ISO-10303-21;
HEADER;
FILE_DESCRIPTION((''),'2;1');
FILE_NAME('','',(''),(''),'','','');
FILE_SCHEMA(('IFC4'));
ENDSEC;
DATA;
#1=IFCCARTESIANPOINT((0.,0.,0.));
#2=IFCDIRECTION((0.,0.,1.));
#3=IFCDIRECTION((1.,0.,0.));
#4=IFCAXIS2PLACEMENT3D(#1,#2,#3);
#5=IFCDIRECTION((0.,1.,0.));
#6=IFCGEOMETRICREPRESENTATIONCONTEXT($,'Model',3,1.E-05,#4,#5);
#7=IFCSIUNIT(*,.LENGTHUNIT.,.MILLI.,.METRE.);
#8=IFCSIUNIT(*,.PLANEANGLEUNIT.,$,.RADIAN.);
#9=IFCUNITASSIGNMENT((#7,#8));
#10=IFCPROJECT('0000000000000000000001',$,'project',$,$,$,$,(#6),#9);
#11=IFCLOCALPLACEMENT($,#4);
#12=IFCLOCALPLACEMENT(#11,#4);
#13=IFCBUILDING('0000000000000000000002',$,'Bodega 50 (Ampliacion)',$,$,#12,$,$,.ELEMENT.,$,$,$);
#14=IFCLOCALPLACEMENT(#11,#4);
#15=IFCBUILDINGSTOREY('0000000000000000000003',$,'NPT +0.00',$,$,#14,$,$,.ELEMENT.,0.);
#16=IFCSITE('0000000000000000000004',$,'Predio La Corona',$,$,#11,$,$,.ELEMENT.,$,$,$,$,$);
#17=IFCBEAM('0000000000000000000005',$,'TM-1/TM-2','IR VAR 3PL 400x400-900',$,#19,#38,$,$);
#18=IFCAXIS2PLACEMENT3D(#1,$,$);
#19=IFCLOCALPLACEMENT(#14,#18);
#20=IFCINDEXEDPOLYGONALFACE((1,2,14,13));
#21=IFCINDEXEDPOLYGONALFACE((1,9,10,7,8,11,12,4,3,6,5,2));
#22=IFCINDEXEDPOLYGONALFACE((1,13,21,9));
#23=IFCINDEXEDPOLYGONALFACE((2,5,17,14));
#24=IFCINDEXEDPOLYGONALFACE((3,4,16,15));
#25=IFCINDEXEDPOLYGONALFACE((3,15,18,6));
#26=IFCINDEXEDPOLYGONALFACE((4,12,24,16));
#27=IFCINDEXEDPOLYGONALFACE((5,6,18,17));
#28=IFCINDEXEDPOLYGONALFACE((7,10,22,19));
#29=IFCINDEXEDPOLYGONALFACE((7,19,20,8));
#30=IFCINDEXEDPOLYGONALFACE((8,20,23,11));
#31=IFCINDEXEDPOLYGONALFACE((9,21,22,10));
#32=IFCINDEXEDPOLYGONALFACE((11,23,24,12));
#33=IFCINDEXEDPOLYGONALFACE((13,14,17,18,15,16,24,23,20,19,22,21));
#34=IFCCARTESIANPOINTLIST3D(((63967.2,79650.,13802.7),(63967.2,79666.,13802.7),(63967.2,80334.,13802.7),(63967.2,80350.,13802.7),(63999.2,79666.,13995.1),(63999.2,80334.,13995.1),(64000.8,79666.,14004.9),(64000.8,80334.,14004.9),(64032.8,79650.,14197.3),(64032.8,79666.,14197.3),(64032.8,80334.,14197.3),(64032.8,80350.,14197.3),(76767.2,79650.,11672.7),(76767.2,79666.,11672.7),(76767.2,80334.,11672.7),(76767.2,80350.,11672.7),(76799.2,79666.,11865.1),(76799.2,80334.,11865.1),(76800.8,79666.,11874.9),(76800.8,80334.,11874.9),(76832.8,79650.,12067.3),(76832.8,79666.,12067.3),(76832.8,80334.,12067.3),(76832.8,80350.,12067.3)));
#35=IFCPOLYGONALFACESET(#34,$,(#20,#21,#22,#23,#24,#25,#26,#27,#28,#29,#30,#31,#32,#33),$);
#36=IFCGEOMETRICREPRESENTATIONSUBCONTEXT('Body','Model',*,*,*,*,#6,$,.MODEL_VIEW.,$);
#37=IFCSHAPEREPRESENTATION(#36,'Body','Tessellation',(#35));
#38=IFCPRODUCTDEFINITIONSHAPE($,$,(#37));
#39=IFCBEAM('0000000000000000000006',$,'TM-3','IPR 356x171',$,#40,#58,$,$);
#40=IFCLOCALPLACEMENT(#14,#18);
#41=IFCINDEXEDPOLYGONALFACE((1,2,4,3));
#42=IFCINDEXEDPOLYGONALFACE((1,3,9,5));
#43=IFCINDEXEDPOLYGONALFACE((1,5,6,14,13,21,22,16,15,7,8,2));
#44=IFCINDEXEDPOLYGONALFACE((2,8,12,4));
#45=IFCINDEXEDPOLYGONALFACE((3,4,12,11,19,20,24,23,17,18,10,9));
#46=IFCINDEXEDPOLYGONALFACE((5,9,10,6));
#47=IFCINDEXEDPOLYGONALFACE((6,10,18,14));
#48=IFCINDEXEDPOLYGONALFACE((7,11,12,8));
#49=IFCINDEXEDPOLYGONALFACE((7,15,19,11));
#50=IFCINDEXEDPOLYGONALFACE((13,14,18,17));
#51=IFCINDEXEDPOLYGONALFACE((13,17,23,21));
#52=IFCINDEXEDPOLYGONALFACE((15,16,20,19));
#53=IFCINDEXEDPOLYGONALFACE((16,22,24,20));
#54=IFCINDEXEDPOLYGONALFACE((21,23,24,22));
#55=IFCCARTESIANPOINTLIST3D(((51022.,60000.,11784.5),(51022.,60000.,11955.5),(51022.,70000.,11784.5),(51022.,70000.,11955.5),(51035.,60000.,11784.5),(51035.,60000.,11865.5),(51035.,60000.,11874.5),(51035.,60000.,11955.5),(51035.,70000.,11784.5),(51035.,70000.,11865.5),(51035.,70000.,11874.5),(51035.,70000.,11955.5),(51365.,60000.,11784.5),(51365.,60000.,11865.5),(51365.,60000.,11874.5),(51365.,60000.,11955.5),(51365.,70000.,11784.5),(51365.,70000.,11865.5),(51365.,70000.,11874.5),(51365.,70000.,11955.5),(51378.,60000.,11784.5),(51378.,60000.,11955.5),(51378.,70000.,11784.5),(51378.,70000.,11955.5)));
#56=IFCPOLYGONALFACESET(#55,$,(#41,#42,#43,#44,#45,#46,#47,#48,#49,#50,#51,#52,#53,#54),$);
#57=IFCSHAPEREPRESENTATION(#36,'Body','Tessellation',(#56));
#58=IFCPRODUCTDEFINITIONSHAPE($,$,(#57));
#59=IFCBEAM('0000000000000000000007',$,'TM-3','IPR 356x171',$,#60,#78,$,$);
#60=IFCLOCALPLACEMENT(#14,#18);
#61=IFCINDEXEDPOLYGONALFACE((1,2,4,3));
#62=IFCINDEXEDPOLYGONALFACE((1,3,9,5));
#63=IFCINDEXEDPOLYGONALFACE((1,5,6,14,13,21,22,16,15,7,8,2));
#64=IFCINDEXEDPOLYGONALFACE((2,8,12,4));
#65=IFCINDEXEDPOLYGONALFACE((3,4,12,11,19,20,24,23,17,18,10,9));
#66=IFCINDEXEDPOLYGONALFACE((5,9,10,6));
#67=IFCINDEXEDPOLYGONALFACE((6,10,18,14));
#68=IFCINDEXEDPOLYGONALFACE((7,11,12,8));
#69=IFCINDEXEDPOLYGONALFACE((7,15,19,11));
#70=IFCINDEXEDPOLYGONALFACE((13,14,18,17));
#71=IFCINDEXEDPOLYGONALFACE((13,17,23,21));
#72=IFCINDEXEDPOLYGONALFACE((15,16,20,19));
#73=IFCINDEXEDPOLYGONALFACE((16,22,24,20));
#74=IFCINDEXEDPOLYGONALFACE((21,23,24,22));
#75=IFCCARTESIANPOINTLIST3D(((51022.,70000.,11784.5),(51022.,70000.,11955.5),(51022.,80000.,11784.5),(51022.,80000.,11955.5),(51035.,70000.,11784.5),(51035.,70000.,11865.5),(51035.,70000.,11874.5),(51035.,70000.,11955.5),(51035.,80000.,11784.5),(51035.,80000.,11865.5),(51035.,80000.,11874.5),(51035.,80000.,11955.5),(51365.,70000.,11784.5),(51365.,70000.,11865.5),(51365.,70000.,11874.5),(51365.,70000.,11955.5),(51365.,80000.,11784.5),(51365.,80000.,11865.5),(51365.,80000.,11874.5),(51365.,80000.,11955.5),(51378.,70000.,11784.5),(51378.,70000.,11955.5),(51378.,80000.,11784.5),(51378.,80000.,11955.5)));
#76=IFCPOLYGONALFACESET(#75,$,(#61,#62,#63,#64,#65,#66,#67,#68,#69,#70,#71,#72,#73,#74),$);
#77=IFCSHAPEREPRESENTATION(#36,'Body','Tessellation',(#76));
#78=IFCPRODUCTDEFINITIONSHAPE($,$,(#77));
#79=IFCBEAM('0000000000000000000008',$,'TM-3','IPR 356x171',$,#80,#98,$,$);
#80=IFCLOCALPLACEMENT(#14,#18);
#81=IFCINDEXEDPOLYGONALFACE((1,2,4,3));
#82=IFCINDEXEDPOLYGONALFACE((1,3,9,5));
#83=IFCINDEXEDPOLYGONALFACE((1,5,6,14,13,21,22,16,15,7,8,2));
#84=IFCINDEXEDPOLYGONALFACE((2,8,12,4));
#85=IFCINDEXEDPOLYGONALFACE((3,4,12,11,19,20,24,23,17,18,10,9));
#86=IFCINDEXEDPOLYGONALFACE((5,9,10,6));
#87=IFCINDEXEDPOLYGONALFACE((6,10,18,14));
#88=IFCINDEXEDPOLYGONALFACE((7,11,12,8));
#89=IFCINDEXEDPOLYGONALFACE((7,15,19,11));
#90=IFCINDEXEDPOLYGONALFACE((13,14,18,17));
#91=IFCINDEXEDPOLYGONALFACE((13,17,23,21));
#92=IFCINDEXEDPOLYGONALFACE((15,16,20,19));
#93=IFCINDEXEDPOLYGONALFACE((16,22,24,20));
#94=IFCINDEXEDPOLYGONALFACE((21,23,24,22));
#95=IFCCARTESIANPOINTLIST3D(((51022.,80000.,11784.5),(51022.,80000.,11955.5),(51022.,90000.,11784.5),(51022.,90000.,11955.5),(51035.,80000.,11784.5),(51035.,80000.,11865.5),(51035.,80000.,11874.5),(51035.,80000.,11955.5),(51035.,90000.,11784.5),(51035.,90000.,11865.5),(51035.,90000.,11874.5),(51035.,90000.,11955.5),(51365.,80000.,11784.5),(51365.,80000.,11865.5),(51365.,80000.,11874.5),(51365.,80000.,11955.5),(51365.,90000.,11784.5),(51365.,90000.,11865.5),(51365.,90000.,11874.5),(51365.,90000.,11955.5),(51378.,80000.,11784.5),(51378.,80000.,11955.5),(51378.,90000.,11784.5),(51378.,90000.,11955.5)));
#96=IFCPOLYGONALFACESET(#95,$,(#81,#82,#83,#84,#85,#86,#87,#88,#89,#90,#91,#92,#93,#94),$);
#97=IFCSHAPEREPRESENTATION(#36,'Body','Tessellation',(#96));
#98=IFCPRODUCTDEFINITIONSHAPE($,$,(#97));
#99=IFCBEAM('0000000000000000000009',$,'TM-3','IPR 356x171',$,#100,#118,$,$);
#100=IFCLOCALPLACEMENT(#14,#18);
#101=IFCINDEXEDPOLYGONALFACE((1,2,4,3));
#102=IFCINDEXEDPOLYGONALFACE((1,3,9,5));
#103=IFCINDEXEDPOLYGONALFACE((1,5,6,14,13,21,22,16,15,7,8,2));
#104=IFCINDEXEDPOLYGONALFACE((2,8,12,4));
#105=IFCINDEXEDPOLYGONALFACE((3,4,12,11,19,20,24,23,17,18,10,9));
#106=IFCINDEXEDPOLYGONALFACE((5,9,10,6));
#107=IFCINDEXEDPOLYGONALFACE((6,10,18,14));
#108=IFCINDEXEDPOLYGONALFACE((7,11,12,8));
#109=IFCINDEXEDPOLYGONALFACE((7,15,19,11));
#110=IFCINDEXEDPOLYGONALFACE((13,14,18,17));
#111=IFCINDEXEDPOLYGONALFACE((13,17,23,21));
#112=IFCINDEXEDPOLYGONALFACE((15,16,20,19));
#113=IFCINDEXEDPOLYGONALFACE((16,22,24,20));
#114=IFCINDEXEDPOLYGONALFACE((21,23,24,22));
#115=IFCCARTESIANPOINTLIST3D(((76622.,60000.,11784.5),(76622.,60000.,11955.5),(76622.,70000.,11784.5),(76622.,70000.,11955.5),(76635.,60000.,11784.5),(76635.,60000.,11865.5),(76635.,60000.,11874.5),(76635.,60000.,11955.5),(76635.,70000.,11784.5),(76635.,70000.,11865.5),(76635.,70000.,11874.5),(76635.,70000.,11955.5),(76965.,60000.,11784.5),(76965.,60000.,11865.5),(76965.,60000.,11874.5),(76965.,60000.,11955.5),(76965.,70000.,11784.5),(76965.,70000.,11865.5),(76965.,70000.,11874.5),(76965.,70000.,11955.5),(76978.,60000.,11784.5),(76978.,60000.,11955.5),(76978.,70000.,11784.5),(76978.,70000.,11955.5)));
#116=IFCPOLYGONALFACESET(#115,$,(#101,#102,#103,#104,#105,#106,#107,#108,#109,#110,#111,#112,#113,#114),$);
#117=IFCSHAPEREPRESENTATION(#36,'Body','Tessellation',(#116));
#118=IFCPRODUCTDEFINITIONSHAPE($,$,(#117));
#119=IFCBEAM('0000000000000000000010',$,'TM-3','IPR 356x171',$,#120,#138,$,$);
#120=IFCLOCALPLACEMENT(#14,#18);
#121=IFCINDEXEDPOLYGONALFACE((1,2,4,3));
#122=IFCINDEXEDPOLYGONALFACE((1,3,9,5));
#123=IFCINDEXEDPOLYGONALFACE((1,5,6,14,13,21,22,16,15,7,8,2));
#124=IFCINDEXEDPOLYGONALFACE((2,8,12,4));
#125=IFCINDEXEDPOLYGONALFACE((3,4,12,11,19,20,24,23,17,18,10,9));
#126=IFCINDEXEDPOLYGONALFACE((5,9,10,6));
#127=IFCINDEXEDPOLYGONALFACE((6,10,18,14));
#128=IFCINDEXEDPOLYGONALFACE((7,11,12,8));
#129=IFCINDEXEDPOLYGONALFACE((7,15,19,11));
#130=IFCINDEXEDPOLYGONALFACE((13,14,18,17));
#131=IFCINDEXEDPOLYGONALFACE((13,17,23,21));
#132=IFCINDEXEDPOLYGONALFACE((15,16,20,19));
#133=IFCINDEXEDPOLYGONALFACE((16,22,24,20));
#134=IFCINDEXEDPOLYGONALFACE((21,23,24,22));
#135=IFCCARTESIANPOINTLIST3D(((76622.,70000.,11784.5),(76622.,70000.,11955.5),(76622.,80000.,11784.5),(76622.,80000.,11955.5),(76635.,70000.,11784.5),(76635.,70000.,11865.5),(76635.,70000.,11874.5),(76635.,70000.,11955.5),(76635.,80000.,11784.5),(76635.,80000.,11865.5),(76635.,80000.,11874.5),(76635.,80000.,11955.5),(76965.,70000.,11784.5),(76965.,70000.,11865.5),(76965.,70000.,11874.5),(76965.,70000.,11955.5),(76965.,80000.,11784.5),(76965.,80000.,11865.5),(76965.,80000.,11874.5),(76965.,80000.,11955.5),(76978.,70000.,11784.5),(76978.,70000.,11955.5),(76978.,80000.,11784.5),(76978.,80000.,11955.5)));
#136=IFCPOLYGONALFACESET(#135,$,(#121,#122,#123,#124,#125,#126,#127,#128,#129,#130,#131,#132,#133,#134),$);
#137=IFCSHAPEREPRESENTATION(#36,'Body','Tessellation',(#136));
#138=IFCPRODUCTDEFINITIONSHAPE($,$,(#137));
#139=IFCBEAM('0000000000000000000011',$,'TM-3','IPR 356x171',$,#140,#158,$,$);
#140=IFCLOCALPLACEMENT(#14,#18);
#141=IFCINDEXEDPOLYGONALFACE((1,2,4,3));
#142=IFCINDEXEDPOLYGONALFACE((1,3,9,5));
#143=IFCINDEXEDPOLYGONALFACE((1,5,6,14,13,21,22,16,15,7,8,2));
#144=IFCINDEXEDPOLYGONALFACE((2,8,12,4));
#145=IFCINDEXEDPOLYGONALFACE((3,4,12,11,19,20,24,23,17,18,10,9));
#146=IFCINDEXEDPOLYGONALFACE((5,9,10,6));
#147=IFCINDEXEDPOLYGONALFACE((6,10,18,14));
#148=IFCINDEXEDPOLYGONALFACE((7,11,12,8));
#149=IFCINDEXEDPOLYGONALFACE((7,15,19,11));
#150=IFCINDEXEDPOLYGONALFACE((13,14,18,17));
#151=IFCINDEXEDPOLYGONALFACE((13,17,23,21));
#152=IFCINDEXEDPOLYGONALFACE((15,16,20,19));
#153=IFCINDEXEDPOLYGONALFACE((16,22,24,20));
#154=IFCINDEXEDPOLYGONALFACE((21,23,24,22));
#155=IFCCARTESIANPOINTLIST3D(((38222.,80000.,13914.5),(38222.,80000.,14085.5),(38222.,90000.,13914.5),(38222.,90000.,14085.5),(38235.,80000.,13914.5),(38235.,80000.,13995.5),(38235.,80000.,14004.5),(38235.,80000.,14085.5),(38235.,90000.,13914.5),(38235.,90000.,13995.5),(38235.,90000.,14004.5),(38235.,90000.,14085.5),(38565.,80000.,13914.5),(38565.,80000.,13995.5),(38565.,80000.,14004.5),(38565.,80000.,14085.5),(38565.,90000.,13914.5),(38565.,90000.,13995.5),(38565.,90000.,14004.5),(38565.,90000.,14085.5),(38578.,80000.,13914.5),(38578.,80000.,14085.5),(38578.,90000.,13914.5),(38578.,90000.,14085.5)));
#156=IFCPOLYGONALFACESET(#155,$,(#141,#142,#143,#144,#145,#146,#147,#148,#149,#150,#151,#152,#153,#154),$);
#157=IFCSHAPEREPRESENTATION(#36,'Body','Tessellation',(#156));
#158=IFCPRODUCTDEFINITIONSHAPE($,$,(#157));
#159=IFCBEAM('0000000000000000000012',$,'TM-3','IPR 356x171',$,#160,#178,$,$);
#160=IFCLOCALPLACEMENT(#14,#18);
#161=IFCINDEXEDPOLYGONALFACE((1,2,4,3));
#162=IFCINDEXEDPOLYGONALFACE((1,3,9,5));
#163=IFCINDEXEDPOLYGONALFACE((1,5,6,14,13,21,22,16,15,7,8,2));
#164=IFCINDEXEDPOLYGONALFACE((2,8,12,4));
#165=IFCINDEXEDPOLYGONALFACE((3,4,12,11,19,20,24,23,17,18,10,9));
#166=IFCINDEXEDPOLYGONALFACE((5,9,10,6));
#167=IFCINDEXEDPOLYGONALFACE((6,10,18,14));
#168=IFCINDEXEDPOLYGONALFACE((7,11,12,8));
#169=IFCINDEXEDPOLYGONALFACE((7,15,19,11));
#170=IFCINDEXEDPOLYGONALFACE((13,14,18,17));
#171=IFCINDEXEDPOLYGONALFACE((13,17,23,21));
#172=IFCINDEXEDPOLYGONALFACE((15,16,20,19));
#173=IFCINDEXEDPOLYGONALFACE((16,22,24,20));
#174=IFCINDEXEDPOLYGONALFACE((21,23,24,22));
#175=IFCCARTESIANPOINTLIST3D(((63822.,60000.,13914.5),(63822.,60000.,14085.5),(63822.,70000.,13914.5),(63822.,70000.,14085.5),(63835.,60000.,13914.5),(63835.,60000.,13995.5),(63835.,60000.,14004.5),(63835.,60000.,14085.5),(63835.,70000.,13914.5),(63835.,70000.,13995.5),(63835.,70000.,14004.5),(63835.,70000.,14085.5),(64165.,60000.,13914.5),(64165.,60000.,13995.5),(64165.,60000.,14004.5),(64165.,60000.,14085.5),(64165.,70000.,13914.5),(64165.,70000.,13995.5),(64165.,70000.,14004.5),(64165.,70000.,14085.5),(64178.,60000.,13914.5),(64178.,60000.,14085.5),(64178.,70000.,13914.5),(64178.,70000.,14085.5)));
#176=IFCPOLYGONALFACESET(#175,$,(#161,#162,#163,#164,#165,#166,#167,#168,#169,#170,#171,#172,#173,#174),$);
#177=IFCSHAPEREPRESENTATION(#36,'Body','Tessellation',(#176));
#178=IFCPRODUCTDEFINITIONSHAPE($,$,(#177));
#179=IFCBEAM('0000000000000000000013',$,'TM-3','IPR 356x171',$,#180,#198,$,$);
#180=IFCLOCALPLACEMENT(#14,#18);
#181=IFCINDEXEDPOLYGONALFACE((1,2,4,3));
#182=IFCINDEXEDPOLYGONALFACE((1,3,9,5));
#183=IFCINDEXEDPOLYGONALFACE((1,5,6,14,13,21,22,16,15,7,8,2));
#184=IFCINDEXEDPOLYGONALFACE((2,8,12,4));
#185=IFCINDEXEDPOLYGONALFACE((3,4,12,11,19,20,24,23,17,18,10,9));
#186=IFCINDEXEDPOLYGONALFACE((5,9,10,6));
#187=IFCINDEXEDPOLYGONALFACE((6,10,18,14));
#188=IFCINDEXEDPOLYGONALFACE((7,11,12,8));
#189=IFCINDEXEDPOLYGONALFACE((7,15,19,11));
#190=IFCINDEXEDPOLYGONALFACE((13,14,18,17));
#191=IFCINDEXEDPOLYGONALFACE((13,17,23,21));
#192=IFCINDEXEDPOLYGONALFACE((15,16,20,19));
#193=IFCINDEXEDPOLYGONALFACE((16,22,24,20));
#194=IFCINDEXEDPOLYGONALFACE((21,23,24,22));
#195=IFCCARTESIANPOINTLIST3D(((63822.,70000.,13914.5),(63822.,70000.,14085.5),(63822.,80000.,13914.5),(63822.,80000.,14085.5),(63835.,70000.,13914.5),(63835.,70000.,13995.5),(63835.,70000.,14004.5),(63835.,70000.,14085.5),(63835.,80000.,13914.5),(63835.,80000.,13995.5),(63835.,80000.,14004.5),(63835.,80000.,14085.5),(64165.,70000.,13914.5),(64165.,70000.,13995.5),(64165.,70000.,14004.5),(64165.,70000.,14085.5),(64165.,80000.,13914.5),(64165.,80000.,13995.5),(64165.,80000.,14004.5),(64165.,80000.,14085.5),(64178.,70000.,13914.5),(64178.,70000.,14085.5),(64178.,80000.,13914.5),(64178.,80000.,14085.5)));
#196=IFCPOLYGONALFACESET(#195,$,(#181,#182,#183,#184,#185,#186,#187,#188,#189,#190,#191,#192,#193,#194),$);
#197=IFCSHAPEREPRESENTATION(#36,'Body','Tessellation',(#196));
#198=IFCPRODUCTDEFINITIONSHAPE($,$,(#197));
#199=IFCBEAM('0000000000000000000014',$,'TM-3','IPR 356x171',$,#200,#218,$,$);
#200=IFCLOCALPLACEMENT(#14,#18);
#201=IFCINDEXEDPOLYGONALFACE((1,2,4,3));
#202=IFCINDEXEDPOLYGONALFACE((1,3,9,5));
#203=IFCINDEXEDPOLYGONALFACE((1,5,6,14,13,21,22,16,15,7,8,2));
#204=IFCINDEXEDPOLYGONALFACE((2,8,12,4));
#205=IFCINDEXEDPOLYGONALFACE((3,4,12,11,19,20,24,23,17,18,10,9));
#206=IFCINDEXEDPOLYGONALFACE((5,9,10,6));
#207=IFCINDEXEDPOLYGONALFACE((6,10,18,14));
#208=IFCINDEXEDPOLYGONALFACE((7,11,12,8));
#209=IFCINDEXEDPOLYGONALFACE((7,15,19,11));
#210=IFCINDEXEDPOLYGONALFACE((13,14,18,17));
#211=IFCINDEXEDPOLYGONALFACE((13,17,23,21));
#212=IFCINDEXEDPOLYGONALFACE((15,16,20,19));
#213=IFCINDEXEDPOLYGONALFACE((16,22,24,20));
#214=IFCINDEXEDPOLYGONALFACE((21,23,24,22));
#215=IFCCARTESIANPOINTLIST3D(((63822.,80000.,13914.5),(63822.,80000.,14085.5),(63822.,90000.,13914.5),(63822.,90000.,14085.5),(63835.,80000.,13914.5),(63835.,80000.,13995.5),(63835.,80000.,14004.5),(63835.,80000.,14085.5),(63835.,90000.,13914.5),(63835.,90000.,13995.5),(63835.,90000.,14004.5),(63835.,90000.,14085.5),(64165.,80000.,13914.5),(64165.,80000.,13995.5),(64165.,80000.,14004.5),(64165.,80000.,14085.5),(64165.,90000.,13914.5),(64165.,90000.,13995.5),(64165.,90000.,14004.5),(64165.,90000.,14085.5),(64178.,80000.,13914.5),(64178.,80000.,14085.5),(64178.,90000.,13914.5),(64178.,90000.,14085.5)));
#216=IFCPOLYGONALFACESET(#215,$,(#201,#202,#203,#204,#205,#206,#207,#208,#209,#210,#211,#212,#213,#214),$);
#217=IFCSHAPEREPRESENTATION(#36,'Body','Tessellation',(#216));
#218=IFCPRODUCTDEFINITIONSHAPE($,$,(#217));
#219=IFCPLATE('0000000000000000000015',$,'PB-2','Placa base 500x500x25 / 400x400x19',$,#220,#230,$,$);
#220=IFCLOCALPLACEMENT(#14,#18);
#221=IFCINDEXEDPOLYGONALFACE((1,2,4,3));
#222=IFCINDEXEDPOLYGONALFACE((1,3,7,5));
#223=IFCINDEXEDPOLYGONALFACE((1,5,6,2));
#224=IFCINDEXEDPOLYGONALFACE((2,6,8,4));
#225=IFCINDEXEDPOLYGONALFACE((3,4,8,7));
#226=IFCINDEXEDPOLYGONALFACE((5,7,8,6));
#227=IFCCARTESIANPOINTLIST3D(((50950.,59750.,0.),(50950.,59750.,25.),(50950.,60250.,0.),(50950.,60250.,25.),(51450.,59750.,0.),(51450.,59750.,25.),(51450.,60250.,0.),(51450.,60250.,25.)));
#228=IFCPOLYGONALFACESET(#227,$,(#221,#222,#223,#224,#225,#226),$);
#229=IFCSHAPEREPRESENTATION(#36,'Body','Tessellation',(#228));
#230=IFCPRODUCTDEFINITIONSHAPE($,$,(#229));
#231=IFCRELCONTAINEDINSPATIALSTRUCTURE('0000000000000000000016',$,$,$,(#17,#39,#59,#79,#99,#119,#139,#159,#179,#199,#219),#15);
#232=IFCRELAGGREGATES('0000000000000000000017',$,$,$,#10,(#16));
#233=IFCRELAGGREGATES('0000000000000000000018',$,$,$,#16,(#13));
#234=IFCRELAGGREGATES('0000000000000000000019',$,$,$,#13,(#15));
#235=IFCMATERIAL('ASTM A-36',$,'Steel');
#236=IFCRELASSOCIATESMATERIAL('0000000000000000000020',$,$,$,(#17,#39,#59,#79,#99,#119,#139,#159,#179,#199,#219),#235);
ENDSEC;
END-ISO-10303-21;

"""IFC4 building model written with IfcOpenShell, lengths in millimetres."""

from ifc_helpers import new_model, si_unit, direction, frame, origin_with_axes, origin_2d, place, context, subcontext, project, spatial, rectangle, i_section, extrude, material, element, save


model = new_model("IFC4")

# Units and contexts
model_context = context("Model", 3, precision=1e-05, world=origin_with_axes(), true_north=direction((0.0, 1.0, 0.0)))
body_context = subcontext(model_context, "Body", "Model", "MODEL_VIEW")
ifc_project = project(units=[si_unit("LENGTHUNIT", "METRE", prefix="MILLI"), si_unit("PLANEANGLEUNIT", "RADIAN")], contexts=[model_context])

# Site, building, storey
site_placement = place(None, origin_with_axes())
site = spatial("IfcSite", under=ifc_project, at=site_placement, Name="Predio La Corona", CompositionType="ELEMENT")
building_placement = place(site_placement, origin_with_axes())
building = spatial("IfcBuilding", under=site, at=building_placement, Name="Bodega 50 (Ampliacion)", CompositionType="ELEMENT")
storey_placement = place(site_placement, origin_with_axes())
storey = spatial("IfcBuildingStorey", under=building, at=storey_placement, Name="NPT +0.00", CompositionType="ELEMENT", Elevation=0.0)

# Shared definitions
ifc_material = material(Name="ASTM A-36", Category="Steel")

# Beams
for number, where, z_axis, x_axis, name in (
    (1, (64000.0, 80000.0, 14000.0), (0.986436, 0.0, -0.164149), (-0.164149, 0.0, -0.986436), "TM-1/TM-2"),
):
    element("IfcBeam", number, at=place(storey_placement, frame(where, z_axis=z_axis, x_axis=x_axis)), inside=storey, material=ifc_material, Name=name, Description="IR VAR 3PL 400x400-900", context=body_context, shape_type="SweptSolid", body=[
        extrude(i_section(OverallWidth=400.0, OverallDepth=700.0, WebThickness=10.0, FlangeThickness=16.0, at=origin_2d()), origin_with_axes(), (0.0, 0.0, 1.0), 12976.0),
    ])
for number, where, z_axis, x_axis, name in (
    (2, (51200.0, 60000.0, 11870.0), (0.0, 1.0, 0.0), (0.0, 0.0, 1.0), "TM-3"),
    (3, (51200.0, 70000.0, 11870.0), (0.0, 1.0, 0.0), (0.0, 0.0, 1.0), "TM-3"),
    (4, (51200.0, 80000.0, 11870.0), (0.0, 1.0, 0.0), (0.0, 0.0, 1.0), "TM-3"),
    (5, (76800.0, 60000.0, 11870.0), (0.0, 1.0, 0.0), (0.0, 0.0, 1.0), "TM-3"),
    (6, (76800.0, 70000.0, 11870.0), (0.0, 1.0, 0.0), (0.0, 0.0, 1.0), "TM-3"),
    (7, (38400.0, 80000.0, 14000.0), (0.0, 1.0, 0.0), (0.0, 0.0, 1.0), "TM-3"),
    (8, (64000.0, 60000.0, 14000.0), (0.0, 1.0, 0.0), (0.0, 0.0, 1.0), "TM-3"),
    (9, (64000.0, 70000.0, 14000.0), (0.0, 1.0, 0.0), (0.0, 0.0, 1.0), "TM-3"),
    (10, (64000.0, 80000.0, 14000.0), (0.0, 1.0, 0.0), (0.0, 0.0, 1.0), "TM-3"),
):
    element("IfcBeam", number, at=place(storey_placement, frame(where, z_axis=z_axis, x_axis=x_axis)), inside=storey, material=ifc_material, Name=name, Description="IPR 356x171", context=body_context, shape_type="SweptSolid", body=[
        extrude(i_section(OverallWidth=171.0, OverallDepth=356.0, WebThickness=9.0, FlangeThickness=13.0, at=origin_2d()), origin_with_axes(), (0.0, 0.0, 1.0), 10000.0),
    ])

# Plate
for number, where, z_axis, x_axis, name in (
    (11, (51200.0, 60000.0, 0.0), (0.0, 0.0, 1.0), (1.0, 0.0, 0.0), "PB-2"),
):
    element("IfcPlate", number, at=place(storey_placement, frame(where, z_axis=z_axis, x_axis=x_axis)), inside=storey, material=ifc_material, Name=name, Description="Placa base 500x500x25 / 400x400x19", context=body_context, shape_type="SweptSolid", body=[
        extrude(rectangle(XDim=500.0, YDim=500.0, at=origin_2d()), origin_with_axes(), (0.0, 0.0, 1.0), 25.0),
    ])

save(model, "model.ifc")
